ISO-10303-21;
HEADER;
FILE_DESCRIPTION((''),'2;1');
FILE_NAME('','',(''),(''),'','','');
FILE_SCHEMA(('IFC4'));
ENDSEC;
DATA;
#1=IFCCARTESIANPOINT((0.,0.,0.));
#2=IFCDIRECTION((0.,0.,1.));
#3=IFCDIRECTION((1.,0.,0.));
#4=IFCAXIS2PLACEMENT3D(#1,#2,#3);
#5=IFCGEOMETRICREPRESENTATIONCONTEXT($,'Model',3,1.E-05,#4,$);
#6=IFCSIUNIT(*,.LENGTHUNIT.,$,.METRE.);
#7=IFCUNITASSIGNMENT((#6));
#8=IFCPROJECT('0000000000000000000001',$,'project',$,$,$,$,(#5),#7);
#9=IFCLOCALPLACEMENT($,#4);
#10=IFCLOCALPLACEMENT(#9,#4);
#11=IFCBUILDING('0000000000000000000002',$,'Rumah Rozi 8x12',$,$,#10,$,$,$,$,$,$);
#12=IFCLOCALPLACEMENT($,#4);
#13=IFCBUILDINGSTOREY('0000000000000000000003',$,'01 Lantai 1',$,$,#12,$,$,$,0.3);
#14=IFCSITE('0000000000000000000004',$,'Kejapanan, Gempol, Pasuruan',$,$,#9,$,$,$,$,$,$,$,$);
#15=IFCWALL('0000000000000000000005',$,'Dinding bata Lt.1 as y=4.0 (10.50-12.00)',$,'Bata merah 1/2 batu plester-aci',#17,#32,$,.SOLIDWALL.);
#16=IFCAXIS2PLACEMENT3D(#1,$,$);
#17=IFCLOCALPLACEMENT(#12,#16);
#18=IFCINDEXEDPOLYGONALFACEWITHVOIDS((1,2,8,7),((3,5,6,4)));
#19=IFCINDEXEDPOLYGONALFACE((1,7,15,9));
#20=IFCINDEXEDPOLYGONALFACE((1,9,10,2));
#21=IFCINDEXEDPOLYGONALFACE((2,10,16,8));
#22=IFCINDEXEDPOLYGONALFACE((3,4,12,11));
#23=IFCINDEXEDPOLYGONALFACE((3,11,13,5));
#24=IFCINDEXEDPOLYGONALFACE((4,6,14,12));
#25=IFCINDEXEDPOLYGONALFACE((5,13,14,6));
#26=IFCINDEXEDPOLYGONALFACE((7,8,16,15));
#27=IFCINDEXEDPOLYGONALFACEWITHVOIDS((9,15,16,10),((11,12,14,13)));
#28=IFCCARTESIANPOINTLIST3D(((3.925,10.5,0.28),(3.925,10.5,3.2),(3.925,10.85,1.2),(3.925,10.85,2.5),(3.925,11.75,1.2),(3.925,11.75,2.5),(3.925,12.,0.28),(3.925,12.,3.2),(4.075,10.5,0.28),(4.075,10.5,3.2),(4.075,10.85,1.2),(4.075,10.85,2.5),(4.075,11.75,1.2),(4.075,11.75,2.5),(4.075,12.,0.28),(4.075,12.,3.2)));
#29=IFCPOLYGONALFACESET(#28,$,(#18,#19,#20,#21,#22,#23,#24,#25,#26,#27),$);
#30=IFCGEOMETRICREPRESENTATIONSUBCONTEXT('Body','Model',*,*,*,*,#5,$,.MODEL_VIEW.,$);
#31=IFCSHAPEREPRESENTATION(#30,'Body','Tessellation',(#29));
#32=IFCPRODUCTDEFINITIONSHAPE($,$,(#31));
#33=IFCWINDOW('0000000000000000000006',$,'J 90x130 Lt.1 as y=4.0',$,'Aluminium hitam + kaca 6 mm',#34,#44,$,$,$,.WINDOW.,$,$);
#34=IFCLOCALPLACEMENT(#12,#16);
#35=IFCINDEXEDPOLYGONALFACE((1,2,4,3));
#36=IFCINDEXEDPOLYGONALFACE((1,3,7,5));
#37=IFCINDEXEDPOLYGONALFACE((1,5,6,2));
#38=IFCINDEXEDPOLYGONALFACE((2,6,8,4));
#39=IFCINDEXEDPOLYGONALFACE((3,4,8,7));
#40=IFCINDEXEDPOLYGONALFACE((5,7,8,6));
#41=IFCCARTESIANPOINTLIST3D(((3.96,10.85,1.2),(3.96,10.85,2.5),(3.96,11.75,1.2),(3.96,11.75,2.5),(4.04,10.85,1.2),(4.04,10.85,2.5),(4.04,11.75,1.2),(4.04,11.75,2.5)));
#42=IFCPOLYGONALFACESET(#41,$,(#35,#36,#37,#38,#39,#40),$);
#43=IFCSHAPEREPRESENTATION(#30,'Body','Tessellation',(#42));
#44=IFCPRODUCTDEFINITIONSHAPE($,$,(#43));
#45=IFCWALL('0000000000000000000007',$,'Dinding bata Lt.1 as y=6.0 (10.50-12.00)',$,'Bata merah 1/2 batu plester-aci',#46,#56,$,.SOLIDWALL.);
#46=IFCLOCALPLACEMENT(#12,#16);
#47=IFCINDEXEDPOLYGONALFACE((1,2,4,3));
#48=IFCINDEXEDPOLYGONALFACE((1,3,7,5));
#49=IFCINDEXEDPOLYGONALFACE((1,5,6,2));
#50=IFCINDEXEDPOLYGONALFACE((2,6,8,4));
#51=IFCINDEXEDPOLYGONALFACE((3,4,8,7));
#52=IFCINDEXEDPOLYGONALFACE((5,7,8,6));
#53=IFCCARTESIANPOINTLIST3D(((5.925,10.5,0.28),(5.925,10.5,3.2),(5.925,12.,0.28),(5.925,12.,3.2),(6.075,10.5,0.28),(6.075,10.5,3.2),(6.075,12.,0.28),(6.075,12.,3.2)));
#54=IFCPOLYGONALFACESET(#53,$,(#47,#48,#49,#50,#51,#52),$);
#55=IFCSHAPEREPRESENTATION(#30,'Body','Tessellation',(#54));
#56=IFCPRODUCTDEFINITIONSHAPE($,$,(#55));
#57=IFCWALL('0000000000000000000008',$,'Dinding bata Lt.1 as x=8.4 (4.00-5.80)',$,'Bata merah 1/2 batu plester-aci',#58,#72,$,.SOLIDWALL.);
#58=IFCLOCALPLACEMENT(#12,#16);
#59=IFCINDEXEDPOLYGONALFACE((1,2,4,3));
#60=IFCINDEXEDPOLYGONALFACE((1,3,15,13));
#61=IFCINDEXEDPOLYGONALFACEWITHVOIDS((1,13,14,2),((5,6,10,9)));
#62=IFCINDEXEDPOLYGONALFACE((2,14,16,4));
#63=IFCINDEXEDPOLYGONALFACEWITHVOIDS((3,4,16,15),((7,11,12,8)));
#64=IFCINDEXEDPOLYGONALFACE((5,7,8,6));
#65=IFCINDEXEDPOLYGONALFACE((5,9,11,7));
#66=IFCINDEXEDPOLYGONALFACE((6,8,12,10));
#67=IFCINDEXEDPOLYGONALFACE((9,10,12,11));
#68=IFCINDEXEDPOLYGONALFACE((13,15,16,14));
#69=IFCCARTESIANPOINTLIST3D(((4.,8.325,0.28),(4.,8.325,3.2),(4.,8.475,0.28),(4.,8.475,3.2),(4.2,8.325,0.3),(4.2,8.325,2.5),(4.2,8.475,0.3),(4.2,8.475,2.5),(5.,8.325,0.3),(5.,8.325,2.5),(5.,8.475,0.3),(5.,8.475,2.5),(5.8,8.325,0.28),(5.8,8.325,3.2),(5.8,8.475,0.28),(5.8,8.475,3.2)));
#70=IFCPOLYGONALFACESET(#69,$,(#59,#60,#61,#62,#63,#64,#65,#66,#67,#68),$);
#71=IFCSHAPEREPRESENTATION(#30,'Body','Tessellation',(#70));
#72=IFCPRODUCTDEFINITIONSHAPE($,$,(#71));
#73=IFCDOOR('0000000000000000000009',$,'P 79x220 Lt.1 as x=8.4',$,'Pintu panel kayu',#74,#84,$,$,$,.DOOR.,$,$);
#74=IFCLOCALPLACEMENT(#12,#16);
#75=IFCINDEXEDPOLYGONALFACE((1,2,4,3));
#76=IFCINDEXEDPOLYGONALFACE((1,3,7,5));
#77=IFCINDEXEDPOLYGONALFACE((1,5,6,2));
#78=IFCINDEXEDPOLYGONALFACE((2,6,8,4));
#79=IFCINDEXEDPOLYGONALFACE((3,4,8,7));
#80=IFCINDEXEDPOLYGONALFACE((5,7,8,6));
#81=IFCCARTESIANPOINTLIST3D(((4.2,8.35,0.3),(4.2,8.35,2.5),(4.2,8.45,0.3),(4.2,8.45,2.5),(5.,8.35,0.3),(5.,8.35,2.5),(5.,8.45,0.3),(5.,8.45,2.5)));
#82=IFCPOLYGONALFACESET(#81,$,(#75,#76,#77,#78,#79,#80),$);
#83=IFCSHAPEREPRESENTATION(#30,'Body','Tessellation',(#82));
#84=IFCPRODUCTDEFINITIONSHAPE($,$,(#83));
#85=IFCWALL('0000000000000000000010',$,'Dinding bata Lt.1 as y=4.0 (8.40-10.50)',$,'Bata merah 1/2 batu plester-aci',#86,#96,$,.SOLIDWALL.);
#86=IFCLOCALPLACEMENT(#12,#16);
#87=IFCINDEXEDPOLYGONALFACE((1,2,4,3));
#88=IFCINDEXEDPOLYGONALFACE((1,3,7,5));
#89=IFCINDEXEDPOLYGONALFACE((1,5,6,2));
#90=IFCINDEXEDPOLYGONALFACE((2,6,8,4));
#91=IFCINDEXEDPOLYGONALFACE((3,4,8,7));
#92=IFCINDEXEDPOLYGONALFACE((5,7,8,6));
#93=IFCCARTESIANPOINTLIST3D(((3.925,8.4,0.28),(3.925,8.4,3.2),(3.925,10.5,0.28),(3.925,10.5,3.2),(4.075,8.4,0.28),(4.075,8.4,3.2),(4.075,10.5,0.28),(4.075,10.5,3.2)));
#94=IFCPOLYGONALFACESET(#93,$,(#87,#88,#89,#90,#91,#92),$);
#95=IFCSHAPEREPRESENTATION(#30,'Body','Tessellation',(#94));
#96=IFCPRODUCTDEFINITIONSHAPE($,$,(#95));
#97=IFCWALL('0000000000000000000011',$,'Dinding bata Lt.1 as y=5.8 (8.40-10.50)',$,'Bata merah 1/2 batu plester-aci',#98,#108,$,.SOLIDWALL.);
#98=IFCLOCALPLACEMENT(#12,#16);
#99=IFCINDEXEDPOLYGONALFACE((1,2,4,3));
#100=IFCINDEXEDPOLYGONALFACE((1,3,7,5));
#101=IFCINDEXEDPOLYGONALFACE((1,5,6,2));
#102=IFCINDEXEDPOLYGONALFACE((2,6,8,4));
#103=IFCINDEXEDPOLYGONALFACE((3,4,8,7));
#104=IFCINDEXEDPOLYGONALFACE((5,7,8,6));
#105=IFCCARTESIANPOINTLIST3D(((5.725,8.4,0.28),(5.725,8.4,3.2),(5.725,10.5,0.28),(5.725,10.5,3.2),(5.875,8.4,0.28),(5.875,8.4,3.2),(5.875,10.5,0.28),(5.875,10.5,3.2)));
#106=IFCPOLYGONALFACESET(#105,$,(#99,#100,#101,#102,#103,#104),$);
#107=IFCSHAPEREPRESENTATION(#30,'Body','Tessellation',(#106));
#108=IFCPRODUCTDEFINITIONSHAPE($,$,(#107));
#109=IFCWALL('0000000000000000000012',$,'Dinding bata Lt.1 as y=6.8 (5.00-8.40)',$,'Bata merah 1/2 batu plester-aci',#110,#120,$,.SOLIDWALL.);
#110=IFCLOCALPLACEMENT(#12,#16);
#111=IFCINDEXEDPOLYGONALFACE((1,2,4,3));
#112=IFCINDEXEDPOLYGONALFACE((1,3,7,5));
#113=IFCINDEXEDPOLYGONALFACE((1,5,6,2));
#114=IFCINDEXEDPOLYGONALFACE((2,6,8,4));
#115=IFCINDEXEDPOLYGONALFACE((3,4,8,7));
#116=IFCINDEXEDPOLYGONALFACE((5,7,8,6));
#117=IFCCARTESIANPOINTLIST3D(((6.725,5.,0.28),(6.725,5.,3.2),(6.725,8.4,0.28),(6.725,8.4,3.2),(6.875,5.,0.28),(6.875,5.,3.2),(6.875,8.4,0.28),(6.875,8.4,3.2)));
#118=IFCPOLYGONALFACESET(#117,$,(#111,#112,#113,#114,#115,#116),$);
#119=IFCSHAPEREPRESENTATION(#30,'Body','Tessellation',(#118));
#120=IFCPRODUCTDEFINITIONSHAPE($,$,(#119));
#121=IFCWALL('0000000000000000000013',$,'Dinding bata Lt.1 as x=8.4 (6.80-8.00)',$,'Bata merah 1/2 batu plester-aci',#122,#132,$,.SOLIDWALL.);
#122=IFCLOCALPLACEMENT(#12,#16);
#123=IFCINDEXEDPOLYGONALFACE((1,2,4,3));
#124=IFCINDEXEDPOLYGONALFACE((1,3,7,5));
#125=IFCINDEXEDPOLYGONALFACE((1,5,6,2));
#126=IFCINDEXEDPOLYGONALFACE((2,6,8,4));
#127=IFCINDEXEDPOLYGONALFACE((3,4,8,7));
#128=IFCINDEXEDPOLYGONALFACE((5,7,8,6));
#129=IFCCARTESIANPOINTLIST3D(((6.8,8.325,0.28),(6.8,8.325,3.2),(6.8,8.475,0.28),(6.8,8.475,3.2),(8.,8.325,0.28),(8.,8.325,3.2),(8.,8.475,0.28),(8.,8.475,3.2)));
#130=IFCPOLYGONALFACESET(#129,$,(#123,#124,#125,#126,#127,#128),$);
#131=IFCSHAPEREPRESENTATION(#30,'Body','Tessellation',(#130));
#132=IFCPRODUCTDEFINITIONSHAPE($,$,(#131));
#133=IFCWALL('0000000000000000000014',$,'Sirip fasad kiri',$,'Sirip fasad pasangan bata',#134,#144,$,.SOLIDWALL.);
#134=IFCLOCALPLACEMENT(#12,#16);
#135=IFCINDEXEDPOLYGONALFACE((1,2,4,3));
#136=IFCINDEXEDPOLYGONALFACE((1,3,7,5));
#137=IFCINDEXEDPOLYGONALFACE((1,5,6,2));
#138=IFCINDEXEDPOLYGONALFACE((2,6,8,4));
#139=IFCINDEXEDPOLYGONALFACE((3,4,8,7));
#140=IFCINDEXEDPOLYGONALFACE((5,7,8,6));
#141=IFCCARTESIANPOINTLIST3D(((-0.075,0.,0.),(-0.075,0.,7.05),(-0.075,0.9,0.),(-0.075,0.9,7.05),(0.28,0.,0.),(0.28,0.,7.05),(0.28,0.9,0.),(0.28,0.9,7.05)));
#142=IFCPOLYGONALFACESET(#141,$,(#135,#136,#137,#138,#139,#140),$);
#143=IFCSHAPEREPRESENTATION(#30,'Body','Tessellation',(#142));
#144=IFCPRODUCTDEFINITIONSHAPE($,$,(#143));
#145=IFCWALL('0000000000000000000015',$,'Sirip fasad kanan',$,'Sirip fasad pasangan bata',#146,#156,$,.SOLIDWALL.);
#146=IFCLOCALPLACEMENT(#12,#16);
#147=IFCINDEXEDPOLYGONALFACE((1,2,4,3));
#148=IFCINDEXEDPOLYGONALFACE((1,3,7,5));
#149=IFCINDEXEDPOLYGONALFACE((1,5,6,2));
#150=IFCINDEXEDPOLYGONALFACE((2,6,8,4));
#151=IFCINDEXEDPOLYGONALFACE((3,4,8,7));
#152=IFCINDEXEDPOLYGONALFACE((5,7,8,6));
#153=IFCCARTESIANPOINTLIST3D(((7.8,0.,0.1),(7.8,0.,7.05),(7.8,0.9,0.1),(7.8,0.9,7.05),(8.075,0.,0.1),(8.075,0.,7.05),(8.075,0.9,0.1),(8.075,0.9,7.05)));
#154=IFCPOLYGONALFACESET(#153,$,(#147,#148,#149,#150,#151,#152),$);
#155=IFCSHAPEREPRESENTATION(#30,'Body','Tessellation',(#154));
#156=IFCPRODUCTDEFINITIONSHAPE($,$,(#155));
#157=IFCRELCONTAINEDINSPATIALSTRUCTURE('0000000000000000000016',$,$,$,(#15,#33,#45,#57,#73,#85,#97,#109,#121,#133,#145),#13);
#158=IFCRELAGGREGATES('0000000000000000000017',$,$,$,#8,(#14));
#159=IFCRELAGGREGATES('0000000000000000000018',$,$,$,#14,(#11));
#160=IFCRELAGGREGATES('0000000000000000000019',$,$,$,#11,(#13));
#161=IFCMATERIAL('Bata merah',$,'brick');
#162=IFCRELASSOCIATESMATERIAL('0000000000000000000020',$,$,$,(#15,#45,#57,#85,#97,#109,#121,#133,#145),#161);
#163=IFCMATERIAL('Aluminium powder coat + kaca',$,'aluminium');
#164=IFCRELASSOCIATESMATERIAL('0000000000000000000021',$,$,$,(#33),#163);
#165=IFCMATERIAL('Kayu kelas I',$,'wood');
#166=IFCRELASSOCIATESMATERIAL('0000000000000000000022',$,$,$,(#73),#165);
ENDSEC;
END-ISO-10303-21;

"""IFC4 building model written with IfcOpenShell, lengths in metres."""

from ifc_helpers import new_model, si_unit, frame, origin_with_axes, place, context, subcontext, project, spatial, line, indexed_curve, outline, extrude, material, element, fill, save


model = new_model("IFC4")

# Units and contexts
model_context = context("Model", 3, precision=1e-05, world=origin_with_axes())
body_context = subcontext(model_context, "Body", "Model", "MODEL_VIEW")
ifc_project = project(units=[si_unit("LENGTHUNIT", "METRE")], contexts=[model_context])

# Site, building, storey
site_placement = place(None, origin_with_axes())
site = spatial("IfcSite", under=ifc_project, at=site_placement, Name="Kejapanan, Gempol, Pasuruan")
building_placement = place(site_placement, origin_with_axes())
building = spatial("IfcBuilding", under=site, at=building_placement, Name="Rumah Rozi 8x12")
storey_placement = place(None, origin_with_axes())
storey = spatial("IfcBuildingStorey", under=building, at=storey_placement, Name="01 Lantai 1", Elevation=0.3)

# Wall, opening, window
ifc_material_1 = material(Name="Bata merah", Category="brick")
wall_1_placement = place(storey_placement, origin_with_axes())
wall_1 = element("IfcWall", 1, at=wall_1_placement, inside=storey, material=ifc_material_1, Name="Dinding bata Lt.1 as y=4.0 (10.50-12.00)", ObjectType="Bata merah 1/2 batu plester-aci", PredefinedType="SOLIDWALL", context=body_context, shape_type="SweptSolid", body=[
    extrude(outline(indexed_curve([(3.925, 10.5), (4.075, 10.5), (4.075, 12.0), (3.925, 12.0)], segments=[line(1, 2, 3, 4, 1)])), frame((0.0, 0.0, 0.28), z_axis=(0.0, 0.0, 1.0), x_axis=(1.0, 0.0, 0.0)), (0.0, 0.0, 1.0), 2.92),
])
opening_1_placement = place(wall_1_placement, origin_with_axes())
opening_1 = element("IfcOpeningElement", 2, at=opening_1_placement, cuts=wall_1, context=body_context, shape_type="SweptSolid", body=[
    extrude(outline(indexed_curve([(3.915, 10.85), (4.085, 10.85), (4.085, 11.75), (3.915, 11.75)], segments=[line(1, 2, 3, 4, 1)])), frame((0.0, 0.0, 1.2), z_axis=(0.0, 0.0, 1.0), x_axis=(1.0, 0.0, 0.0)), (0.0, 0.0, 1.0), 1.3),
])
ifc_material_2 = material(Name="Aluminium powder coat + kaca", Category="aluminium")
window_placement = place(storey_placement, origin_with_axes())
window = element("IfcWindow", 3, at=window_placement, inside=storey, material=ifc_material_2, Name="J 90x130 Lt.1 as y=4.0", ObjectType="Aluminium hitam + kaca 6 mm", PredefinedType="WINDOW", context=body_context, shape_type="SweptSolid", body=[
    extrude(outline(indexed_curve([(3.96, 10.85), (4.04, 10.85), (4.04, 11.75), (3.96, 11.75)], segments=[line(1, 2, 3, 4, 1)])), frame((0.0, 0.0, 1.2), z_axis=(0.0, 0.0, 1.0), x_axis=(1.0, 0.0, 0.0)), (0.0, 0.0, 1.0), 1.3),
])
fill(opening_1, window)

# Wall
wall_2_placement = place(storey_placement, origin_with_axes())
element("IfcWall", 4, at=wall_2_placement, inside=storey, material=ifc_material_1, Name="Dinding bata Lt.1 as y=6.0 (10.50-12.00)", ObjectType="Bata merah 1/2 batu plester-aci", PredefinedType="SOLIDWALL", context=body_context, shape_type="SweptSolid", body=[
    extrude(outline(indexed_curve([(5.925, 10.5), (6.075, 10.5), (6.075, 12.0), (5.925, 12.0)], segments=[line(1, 2, 3, 4, 1)])), frame((0.0, 0.0, 0.28), z_axis=(0.0, 0.0, 1.0), x_axis=(1.0, 0.0, 0.0)), (0.0, 0.0, 1.0), 2.92),
])

# Wall, opening, door
wall_3_placement = place(storey_placement, origin_with_axes())
wall_3 = element("IfcWall", 5, at=wall_3_placement, inside=storey, material=ifc_material_1, Name="Dinding bata Lt.1 as x=8.4 (4.00-5.80)", ObjectType="Bata merah 1/2 batu plester-aci", PredefinedType="SOLIDWALL", context=body_context, shape_type="SweptSolid", body=[
    extrude(outline(indexed_curve([(4.0, 8.325), (5.8, 8.325), (5.8, 8.475), (4.0, 8.475)], segments=[line(1, 2, 3, 4, 1)])), frame((0.0, 0.0, 0.28), z_axis=(0.0, 0.0, 1.0), x_axis=(1.0, 0.0, 0.0)), (0.0, 0.0, 1.0), 2.92),
])
opening_2_placement = place(wall_3_placement, origin_with_axes())
opening_2 = element("IfcOpeningElement", 6, at=opening_2_placement, cuts=wall_3, context=body_context, shape_type="SweptSolid", body=[
    extrude(outline(indexed_curve([(4.2, 8.315), (5.0, 8.315), (5.0, 8.485), (4.2, 8.485)], segments=[line(1, 2, 3, 4, 1)])), frame((0.0, 0.0, 0.3), z_axis=(0.0, 0.0, 1.0), x_axis=(1.0, 0.0, 0.0)), (0.0, 0.0, 1.0), 2.2),
])
ifc_material_3 = material(Name="Kayu kelas I", Category="wood")
door_placement = place(storey_placement, origin_with_axes())
door = element("IfcDoor", 7, at=door_placement, inside=storey, material=ifc_material_3, Name="P 79x220 Lt.1 as x=8.4", ObjectType="Pintu panel kayu", PredefinedType="DOOR", context=body_context, shape_type="SweptSolid", body=[
    extrude(outline(indexed_curve([(4.2, 8.35), (5.0, 8.35), (5.0, 8.45), (4.2, 8.45)], segments=[line(1, 2, 3, 4, 1)])), frame((0.0, 0.0, 0.3), z_axis=(0.0, 0.0, 1.0), x_axis=(1.0, 0.0, 0.0)), (0.0, 0.0, 1.0), 2.2),
])
fill(opening_2, door)

# Walls
wall_4_placement = place(storey_placement, origin_with_axes())
element("IfcWall", 8, at=wall_4_placement, inside=storey, material=ifc_material_1, Name="Dinding bata Lt.1 as y=4.0 (8.40-10.50)", ObjectType="Bata merah 1/2 batu plester-aci", PredefinedType="SOLIDWALL", context=body_context, shape_type="SweptSolid", body=[
    extrude(outline(indexed_curve([(3.925, 8.4), (4.075, 8.4), (4.075, 10.5), (3.925, 10.5)], segments=[line(1, 2, 3, 4, 1)])), frame((0.0, 0.0, 0.28), z_axis=(0.0, 0.0, 1.0), x_axis=(1.0, 0.0, 0.0)), (0.0, 0.0, 1.0), 2.92),
])
wall_5_placement = place(storey_placement, origin_with_axes())
element("IfcWall", 9, at=wall_5_placement, inside=storey, material=ifc_material_1, Name="Dinding bata Lt.1 as y=5.8 (8.40-10.50)", ObjectType="Bata merah 1/2 batu plester-aci", PredefinedType="SOLIDWALL", context=body_context, shape_type="SweptSolid", body=[
    extrude(outline(indexed_curve([(5.725, 8.4), (5.875, 8.4), (5.875, 10.5), (5.725, 10.5)], segments=[line(1, 2, 3, 4, 1)])), frame((0.0, 0.0, 0.28), z_axis=(0.0, 0.0, 1.0), x_axis=(1.0, 0.0, 0.0)), (0.0, 0.0, 1.0), 2.92),
])
wall_6_placement = place(storey_placement, origin_with_axes())
element("IfcWall", 10, at=wall_6_placement, inside=storey, material=ifc_material_1, Name="Dinding bata Lt.1 as y=6.8 (5.00-8.40)", ObjectType="Bata merah 1/2 batu plester-aci", PredefinedType="SOLIDWALL", context=body_context, shape_type="SweptSolid", body=[
    extrude(outline(indexed_curve([(6.725, 5.0), (6.875, 5.0), (6.875, 8.4), (6.725, 8.4)], segments=[line(1, 2, 3, 4, 1)])), frame((0.0, 0.0, 0.28), z_axis=(0.0, 0.0, 1.0), x_axis=(1.0, 0.0, 0.0)), (0.0, 0.0, 1.0), 2.92),
])
wall_7_placement = place(storey_placement, origin_with_axes())
element("IfcWall", 11, at=wall_7_placement, inside=storey, material=ifc_material_1, Name="Dinding bata Lt.1 as x=8.4 (6.80-8.00)", ObjectType="Bata merah 1/2 batu plester-aci", PredefinedType="SOLIDWALL", context=body_context, shape_type="SweptSolid", body=[
    extrude(outline(indexed_curve([(6.8, 8.325), (8.0, 8.325), (8.0, 8.475), (6.8, 8.475)], segments=[line(1, 2, 3, 4, 1)])), frame((0.0, 0.0, 0.28), z_axis=(0.0, 0.0, 1.0), x_axis=(1.0, 0.0, 0.0)), (0.0, 0.0, 1.0), 2.92),
])
wall_8_placement = place(storey_placement, origin_with_axes())
element("IfcWall", 12, at=wall_8_placement, inside=storey, material=ifc_material_1, Name="Sirip fasad kiri", ObjectType="Sirip fasad pasangan bata", PredefinedType="SOLIDWALL", context=body_context, shape_type="SweptSolid", body=[
    extrude(outline(indexed_curve([(-0.075, 0.0), (0.28, 0.0), (0.28, 0.9), (-0.075, 0.9)], segments=[line(1, 2, 3, 4, 1)])), origin_with_axes(), (0.0, 0.0, 1.0), 7.05),
])
wall_9_placement = place(storey_placement, origin_with_axes())
element("IfcWall", 13, at=wall_9_placement, inside=storey, material=ifc_material_1, Name="Sirip fasad kanan", ObjectType="Sirip fasad pasangan bata", PredefinedType="SOLIDWALL", context=body_context, shape_type="SweptSolid", body=[
    extrude(outline(indexed_curve([(7.8, 0.0), (8.075, 0.0), (8.075, 0.9), (7.8, 0.9)], segments=[line(1, 2, 3, 4, 1)])), frame((0.0, 0.0, 0.1), z_axis=(0.0, 0.0, 1.0), x_axis=(1.0, 0.0, 0.0)), (0.0, 0.0, 1.0), 6.95),
])

save(model, "model.ifc")
